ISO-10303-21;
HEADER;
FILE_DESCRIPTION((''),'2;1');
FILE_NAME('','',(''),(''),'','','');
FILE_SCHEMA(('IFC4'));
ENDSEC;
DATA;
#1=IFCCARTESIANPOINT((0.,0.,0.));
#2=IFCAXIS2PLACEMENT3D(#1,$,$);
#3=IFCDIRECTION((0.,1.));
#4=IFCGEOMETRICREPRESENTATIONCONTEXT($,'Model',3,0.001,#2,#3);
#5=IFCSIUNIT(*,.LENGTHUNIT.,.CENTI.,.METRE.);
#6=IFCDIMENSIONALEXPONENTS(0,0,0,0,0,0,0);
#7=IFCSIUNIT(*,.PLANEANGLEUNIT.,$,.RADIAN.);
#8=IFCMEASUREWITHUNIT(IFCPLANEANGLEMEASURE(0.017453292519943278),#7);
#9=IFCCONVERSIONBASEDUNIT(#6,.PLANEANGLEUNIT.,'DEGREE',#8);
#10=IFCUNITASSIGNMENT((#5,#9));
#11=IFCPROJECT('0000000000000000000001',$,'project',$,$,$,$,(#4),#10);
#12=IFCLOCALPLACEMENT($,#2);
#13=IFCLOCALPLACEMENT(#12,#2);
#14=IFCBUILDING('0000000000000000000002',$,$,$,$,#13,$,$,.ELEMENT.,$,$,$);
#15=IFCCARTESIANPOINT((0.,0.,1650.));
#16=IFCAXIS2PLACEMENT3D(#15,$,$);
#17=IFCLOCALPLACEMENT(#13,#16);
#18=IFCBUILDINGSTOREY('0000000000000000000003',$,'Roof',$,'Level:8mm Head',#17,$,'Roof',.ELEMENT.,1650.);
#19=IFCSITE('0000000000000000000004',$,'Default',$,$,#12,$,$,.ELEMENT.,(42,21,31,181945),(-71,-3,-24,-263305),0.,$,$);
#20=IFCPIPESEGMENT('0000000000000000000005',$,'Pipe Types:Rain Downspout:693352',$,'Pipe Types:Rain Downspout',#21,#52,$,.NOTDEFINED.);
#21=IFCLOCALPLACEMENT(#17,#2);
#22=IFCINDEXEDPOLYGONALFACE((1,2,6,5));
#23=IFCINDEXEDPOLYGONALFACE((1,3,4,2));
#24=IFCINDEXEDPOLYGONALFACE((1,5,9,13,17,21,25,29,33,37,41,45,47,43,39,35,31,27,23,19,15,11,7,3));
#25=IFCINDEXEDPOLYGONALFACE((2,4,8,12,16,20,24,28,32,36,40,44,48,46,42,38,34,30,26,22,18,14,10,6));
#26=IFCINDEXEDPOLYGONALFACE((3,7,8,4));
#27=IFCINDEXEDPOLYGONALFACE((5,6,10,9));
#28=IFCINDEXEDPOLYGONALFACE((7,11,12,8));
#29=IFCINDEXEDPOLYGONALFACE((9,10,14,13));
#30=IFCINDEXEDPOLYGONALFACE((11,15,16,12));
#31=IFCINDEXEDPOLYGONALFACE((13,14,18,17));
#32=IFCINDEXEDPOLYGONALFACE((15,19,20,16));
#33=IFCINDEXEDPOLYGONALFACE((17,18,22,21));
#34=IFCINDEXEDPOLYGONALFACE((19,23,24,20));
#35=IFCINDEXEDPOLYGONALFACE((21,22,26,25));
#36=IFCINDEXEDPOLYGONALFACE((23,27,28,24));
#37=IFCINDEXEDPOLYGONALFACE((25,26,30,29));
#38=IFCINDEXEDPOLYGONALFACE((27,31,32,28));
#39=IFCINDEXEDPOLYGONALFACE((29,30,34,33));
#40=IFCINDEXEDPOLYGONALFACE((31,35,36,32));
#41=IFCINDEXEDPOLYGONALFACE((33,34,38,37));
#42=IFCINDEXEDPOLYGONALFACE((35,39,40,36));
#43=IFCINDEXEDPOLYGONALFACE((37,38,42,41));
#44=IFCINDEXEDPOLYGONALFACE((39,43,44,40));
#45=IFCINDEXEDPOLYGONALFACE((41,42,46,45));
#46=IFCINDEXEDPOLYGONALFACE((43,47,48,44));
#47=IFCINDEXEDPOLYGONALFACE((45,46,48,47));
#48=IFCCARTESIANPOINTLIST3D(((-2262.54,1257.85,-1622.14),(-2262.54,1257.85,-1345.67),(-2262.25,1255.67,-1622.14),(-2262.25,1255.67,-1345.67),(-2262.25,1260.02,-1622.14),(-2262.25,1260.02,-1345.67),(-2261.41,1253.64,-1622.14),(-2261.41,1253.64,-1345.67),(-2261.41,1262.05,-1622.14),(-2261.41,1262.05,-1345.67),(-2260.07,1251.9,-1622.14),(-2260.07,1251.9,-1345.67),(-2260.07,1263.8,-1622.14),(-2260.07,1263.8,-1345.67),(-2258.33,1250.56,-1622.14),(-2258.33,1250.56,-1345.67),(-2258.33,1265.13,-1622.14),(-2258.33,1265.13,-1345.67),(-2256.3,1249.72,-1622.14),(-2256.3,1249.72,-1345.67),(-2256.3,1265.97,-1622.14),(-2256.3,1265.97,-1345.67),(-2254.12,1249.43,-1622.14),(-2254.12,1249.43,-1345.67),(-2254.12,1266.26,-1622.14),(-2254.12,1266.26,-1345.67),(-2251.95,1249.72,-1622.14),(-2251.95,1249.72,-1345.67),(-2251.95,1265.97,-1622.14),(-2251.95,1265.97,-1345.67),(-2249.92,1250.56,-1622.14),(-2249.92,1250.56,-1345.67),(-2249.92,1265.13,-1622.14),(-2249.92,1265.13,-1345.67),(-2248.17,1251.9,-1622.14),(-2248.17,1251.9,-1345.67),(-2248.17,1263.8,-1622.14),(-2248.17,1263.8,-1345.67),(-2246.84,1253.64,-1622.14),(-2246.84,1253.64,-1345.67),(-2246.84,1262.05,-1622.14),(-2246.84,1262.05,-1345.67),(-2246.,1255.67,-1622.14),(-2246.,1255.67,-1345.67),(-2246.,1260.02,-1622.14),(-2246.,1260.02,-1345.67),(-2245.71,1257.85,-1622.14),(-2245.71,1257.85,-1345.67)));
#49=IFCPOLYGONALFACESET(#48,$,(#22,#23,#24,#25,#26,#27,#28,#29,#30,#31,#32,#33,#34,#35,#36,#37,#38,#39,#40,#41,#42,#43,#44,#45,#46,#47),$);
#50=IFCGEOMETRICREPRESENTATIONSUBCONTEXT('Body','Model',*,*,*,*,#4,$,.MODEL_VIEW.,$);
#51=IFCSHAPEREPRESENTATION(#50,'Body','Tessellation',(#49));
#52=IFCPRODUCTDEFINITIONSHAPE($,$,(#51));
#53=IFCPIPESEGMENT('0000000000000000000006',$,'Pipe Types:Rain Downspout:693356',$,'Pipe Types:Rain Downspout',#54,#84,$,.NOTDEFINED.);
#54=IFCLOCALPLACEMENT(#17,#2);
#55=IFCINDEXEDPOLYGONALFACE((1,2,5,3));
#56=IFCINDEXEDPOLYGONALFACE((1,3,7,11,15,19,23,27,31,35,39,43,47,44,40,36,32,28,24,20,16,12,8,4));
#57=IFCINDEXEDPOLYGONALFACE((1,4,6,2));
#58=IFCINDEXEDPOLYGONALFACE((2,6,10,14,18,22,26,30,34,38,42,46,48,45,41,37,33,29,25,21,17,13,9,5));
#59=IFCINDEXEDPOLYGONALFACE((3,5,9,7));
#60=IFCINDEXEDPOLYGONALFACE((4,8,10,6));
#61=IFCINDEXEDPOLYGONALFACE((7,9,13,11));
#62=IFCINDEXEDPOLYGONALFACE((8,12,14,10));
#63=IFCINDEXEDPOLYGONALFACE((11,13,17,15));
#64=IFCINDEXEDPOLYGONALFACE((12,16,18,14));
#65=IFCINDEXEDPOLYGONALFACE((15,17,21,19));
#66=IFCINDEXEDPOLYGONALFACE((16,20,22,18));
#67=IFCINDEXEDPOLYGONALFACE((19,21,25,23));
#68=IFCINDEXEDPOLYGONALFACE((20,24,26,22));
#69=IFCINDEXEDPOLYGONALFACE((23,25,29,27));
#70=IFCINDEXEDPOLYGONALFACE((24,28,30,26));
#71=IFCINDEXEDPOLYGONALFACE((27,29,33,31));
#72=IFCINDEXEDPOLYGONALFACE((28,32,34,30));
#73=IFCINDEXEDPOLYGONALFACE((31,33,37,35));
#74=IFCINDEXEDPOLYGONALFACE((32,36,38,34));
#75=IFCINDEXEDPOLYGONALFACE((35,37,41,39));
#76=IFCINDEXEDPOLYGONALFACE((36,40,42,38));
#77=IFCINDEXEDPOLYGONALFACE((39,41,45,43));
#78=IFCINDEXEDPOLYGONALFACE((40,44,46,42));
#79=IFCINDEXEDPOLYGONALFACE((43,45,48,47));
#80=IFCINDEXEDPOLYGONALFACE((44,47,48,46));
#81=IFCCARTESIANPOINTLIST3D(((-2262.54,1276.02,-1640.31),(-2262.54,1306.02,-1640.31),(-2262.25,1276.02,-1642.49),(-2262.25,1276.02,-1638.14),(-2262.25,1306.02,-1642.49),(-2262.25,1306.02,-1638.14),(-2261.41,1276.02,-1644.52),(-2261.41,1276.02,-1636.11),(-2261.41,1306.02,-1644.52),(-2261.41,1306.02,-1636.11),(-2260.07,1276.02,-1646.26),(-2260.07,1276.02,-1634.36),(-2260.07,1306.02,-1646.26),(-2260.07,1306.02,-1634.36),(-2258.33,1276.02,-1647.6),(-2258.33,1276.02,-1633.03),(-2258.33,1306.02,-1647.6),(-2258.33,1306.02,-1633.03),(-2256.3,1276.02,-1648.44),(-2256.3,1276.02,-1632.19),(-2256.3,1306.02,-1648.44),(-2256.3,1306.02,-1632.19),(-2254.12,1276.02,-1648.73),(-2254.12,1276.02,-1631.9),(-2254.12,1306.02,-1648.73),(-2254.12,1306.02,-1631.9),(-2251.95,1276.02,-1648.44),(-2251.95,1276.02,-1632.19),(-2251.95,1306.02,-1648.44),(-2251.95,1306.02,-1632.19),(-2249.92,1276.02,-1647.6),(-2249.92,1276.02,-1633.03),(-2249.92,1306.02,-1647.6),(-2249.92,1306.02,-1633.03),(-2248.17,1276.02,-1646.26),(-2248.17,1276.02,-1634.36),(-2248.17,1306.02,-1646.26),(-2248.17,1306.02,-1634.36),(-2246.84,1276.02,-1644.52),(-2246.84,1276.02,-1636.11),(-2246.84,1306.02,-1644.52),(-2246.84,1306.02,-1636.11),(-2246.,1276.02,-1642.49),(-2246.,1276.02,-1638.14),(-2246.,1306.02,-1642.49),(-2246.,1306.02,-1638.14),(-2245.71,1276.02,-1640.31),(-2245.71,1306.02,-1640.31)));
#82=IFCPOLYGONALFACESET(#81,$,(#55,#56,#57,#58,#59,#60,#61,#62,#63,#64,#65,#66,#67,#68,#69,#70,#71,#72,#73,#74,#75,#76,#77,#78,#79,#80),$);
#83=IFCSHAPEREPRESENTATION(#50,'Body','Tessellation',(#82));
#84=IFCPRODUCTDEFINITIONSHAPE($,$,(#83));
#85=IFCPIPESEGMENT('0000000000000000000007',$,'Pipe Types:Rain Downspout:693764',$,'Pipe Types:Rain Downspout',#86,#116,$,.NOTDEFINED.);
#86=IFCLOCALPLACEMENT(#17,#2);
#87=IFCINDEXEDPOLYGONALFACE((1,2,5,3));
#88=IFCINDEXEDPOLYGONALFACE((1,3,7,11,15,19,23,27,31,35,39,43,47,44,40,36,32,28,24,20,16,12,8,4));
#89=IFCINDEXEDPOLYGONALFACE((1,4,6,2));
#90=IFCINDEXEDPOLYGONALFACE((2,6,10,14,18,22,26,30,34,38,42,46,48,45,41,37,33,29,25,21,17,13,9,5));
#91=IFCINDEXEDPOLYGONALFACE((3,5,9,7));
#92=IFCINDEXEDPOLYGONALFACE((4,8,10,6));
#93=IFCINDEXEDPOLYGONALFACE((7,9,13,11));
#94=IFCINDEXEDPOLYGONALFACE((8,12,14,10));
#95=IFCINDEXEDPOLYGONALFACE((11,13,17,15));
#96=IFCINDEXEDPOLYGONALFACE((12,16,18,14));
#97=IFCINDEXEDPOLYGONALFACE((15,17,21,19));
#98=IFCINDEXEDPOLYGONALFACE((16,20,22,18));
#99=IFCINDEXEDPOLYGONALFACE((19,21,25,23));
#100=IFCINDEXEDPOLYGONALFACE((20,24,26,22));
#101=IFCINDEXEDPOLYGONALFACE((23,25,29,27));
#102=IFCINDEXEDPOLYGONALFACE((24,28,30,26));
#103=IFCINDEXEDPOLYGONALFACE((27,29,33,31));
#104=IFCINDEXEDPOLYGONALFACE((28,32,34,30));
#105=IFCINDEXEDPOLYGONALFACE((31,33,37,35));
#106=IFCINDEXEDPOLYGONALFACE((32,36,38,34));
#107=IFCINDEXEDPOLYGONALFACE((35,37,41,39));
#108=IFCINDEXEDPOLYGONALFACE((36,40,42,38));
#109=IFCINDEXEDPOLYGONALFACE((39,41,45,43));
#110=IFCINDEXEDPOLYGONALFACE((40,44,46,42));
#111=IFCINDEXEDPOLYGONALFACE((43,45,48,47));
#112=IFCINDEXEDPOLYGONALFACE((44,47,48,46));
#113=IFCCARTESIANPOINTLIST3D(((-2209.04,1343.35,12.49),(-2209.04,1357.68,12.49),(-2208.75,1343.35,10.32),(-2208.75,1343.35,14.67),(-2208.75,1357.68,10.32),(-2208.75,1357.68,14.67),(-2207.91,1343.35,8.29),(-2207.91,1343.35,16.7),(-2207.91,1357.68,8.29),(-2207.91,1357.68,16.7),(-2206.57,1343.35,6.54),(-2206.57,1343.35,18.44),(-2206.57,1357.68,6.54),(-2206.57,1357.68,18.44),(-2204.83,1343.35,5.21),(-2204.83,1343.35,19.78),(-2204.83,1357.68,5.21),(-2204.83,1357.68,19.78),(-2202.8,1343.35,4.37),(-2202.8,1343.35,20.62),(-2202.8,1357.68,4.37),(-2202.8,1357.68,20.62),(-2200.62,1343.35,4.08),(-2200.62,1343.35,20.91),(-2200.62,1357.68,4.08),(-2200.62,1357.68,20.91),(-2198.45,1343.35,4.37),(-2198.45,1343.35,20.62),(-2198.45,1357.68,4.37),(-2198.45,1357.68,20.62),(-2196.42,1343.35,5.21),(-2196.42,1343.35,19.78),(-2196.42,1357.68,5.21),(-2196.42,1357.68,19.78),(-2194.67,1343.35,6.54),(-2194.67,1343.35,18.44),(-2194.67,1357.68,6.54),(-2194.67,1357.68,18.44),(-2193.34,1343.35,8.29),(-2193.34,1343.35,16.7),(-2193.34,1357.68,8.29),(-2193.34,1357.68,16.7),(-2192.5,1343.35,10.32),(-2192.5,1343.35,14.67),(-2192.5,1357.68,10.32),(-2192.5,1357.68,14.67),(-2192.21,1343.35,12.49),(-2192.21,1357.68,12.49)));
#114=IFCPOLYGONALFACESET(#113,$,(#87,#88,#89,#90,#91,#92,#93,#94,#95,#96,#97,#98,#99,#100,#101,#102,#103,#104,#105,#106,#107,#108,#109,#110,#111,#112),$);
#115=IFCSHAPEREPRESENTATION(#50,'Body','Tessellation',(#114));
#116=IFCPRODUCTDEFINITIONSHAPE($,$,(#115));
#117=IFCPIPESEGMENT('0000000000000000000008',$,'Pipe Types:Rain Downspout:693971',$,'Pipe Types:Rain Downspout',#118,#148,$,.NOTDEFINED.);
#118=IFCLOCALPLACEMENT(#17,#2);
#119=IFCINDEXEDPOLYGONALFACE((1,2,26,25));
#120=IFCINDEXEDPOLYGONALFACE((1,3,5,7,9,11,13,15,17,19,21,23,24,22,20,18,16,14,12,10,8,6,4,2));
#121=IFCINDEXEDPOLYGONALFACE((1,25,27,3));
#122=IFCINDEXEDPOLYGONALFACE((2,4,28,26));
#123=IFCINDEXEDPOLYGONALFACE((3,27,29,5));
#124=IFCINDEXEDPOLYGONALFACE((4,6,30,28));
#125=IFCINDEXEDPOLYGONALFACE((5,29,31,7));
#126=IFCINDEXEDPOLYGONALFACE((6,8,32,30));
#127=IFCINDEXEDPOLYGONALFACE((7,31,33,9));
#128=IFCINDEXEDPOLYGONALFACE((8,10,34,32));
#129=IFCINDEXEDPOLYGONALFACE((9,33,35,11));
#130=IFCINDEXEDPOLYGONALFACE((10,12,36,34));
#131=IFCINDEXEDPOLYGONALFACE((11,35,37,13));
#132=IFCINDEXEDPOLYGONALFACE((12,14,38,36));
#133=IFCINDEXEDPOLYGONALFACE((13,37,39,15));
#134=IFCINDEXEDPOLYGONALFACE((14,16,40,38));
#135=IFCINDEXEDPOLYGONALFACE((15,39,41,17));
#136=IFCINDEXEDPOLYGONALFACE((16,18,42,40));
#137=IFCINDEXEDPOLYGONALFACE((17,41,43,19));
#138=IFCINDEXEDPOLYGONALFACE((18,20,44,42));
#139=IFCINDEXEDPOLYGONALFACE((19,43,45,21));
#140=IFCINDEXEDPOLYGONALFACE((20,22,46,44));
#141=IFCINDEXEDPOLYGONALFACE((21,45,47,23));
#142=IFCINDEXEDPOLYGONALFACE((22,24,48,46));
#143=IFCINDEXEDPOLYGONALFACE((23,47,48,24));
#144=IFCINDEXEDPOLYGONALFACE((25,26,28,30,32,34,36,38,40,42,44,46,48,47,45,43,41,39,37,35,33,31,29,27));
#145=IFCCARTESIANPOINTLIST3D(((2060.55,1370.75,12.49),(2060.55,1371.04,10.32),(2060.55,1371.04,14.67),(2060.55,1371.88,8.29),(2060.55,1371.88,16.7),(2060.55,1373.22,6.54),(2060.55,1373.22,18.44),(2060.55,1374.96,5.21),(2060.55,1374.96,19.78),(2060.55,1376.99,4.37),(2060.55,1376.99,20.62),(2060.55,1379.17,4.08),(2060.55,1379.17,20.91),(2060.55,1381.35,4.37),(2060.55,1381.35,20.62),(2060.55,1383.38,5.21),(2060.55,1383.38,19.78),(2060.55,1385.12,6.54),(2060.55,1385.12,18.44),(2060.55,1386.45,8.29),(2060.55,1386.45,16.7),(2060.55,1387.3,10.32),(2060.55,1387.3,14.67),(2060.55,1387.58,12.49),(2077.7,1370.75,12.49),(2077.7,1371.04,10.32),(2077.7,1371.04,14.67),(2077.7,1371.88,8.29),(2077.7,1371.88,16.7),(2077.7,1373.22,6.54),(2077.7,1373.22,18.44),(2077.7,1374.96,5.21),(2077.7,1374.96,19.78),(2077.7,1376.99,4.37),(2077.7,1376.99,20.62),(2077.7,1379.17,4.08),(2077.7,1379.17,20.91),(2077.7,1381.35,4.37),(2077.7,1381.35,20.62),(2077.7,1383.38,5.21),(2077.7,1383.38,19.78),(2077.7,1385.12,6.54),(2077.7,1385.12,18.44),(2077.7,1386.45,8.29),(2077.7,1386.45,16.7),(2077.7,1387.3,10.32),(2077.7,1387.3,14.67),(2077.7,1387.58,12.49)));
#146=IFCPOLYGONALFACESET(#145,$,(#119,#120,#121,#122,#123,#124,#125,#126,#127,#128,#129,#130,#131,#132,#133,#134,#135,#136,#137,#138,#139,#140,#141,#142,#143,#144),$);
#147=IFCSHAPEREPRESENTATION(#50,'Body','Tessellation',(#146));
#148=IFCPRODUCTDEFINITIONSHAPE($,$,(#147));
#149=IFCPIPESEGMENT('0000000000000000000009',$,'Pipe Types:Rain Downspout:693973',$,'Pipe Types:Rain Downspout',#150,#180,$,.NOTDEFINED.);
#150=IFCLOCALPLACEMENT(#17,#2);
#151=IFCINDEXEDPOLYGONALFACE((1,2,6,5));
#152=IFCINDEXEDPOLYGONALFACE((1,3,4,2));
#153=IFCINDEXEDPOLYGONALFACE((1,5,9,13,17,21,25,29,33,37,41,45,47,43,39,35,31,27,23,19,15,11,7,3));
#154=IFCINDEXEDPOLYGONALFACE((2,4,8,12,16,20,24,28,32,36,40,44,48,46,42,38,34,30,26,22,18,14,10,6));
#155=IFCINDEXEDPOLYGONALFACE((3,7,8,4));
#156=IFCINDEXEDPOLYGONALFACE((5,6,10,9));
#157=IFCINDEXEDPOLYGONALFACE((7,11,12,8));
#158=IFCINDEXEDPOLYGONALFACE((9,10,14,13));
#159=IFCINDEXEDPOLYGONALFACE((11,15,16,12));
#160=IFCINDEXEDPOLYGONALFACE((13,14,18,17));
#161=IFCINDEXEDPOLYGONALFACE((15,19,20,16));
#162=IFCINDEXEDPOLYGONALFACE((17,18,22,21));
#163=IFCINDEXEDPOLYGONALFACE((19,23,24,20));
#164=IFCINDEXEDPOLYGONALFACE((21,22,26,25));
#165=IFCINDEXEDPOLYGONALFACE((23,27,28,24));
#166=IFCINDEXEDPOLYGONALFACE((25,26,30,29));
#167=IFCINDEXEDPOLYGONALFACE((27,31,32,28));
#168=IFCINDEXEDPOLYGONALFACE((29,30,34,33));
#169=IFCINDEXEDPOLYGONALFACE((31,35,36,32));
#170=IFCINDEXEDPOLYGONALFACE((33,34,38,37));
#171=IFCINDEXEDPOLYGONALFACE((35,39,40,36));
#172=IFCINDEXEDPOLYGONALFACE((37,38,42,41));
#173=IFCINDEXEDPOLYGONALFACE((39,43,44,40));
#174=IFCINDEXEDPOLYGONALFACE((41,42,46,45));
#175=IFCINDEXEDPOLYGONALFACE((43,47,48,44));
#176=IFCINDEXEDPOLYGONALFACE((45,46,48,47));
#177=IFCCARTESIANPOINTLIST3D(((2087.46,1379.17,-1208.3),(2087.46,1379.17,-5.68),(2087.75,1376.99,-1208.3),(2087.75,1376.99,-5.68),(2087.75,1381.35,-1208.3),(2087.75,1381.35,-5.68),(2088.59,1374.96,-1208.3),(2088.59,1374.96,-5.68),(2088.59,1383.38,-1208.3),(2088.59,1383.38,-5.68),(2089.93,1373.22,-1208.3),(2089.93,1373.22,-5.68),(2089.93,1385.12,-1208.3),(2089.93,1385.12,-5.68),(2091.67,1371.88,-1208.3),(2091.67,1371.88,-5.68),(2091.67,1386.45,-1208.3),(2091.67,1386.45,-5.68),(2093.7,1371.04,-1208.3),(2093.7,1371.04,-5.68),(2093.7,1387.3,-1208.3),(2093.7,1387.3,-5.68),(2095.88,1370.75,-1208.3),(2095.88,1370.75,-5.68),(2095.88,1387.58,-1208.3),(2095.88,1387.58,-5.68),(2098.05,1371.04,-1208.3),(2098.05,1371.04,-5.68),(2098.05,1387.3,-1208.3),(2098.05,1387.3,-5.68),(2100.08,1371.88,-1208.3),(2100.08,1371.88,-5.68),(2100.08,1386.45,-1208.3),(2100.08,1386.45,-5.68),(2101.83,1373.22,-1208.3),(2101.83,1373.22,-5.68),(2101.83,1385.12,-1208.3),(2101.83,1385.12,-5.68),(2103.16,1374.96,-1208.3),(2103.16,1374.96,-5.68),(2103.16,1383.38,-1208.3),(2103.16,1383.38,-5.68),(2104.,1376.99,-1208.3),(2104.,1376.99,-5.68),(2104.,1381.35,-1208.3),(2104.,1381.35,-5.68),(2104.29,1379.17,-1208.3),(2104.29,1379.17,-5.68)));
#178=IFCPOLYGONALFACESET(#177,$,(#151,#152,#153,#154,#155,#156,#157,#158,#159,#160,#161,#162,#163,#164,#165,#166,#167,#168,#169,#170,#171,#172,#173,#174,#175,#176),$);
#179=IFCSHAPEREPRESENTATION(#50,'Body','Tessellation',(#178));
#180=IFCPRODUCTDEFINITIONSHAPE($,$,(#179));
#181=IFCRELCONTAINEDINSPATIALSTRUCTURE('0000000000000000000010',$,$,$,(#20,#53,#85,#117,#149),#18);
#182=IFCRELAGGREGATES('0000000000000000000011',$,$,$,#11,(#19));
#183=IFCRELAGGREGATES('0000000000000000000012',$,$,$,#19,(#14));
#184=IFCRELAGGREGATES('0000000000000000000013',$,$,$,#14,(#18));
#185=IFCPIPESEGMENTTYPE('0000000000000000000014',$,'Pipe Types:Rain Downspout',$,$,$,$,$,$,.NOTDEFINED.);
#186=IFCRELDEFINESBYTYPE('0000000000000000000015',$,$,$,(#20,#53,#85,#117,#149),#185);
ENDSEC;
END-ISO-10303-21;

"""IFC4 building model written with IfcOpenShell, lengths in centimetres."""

from ifc_helpers import new_model, entity, si_unit, converted_unit, direction, frame, origin, place, context, subcontext, project, spatial, arc, indexed_curve, outline, extrude, type_object, element, save


model = new_model("IFC4")

# Units and contexts
model_context = context("Model", 3, precision=0.001, world=origin(), true_north=direction((0.0, 1.0)))
body_context = subcontext(model_context, "Body", "Model", "MODEL_VIEW")
ifc_project = project(units=[si_unit("LENGTHUNIT", "METRE", prefix="CENTI"), converted_unit("PLANEANGLEUNIT", "DEGREE", entity("IfcPlaneAngleMeasure", 0.017453292519943278), si_unit("PLANEANGLEUNIT", "RADIAN"), dimensions=[0, 0, 0, 0, 0, 0, 0])], contexts=[model_context])

# Site, building, storey
site_placement = place(None, origin())
site = spatial("IfcSite", under=ifc_project, at=site_placement, Name="Default", CompositionType="ELEMENT", RefLatitude=(42, 21, 31, 181945), RefLongitude=(-71, -3, -24, -263305), RefElevation=0.0)
building_placement = place(site_placement, origin())
building = spatial("IfcBuilding", under=site, at=building_placement, CompositionType="ELEMENT")
storey_placement = place(building_placement, frame((0.0, 0.0, 1650.0)))
storey = spatial("IfcBuildingStorey", under=building, at=storey_placement, Name="Roof", ObjectType="Level:8mm Head", LongName="Roof", CompositionType="ELEMENT", Elevation=1650.0)

# Pipe segments
pipe_segment_type = type_object("IfcPipeSegmentType", Name="Pipe Types:Rain Downspout", PredefinedType="NOTDEFINED")
pipe_segment_1_placement = place(storey_placement, origin())
element("IfcPipeSegment", 1, at=pipe_segment_1_placement, inside=storey, type_object=pipe_segment_type, Name="Pipe Types:Rain Downspout:693352", ObjectType="Pipe Types:Rain Downspout", PredefinedType="NOTDEFINED", context=body_context, shape_type="SweptSolid", body=[
    extrude(outline(indexed_curve([(8.41, 0.0), (5.95, 5.95), (0.0, 8.41), (-5.95, 5.95), (-8.41, 0.0), (-5.95, -5.95), (0.0, -8.41), (5.95, -5.95)], segments=[arc(1, 2, 3), arc(3, 4, 5), arc(5, 6, 7), arc(7, 8, 1)], self_intersect=False)), frame((-2254.12, 1257.85, -1622.14)), (0.0, 0.0, 1.0), 276.47),
])
pipe_segment_2_placement = place(storey_placement, origin())
element("IfcPipeSegment", 2, at=pipe_segment_2_placement, inside=storey, type_object=pipe_segment_type, Name="Pipe Types:Rain Downspout:693356", ObjectType="Pipe Types:Rain Downspout", PredefinedType="NOTDEFINED", context=body_context, shape_type="SweptSolid", body=[
    extrude(outline(indexed_curve([(8.41, 0.0), (5.95, 5.95), (0.0, 8.41), (-5.95, 5.95), (-8.41, 0.0), (-5.95, -5.95), (0.0, -8.41), (5.95, -5.95)], segments=[arc(1, 2, 3), arc(3, 4, 5), arc(5, 6, 7), arc(7, 8, 1)], self_intersect=False)), frame((-2254.12, 1276.02, -1640.31), z_axis=(0.0, 1.0, 0.0), x_axis=(1.0, 0.0, 0.0)), (0.0, 0.0, 1.0), 30.0),
])
pipe_segment_3_placement = place(storey_placement, origin())
element("IfcPipeSegment", 3, at=pipe_segment_3_placement, inside=storey, type_object=pipe_segment_type, Name="Pipe Types:Rain Downspout:693764", ObjectType="Pipe Types:Rain Downspout", PredefinedType="NOTDEFINED", context=body_context, shape_type="SweptSolid", body=[
    extrude(outline(indexed_curve([(8.41, 0.0), (5.95, 5.95), (0.0, 8.41), (-5.95, 5.95), (-8.41, 0.0), (-5.95, -5.95), (0.0, -8.41), (5.95, -5.95)], segments=[arc(1, 2, 3), arc(3, 4, 5), arc(5, 6, 7), arc(7, 8, 1)], self_intersect=False)), frame((-2200.62, 1343.35, 12.49), z_axis=(0.0, 1.0, 0.0), x_axis=(-1.0, 0.0, 0.0)), (0.0, 0.0, 1.0), 14.34),
])
pipe_segment_4_placement = place(storey_placement, origin())
element("IfcPipeSegment", 4, at=pipe_segment_4_placement, inside=storey, type_object=pipe_segment_type, Name="Pipe Types:Rain Downspout:693971", ObjectType="Pipe Types:Rain Downspout", PredefinedType="NOTDEFINED", context=body_context, shape_type="SweptSolid", body=[
    extrude(outline(indexed_curve([(8.41, 0.0), (5.95, 5.95), (0.0, 8.41), (-5.95, 5.95), (-8.41, 0.0), (-5.95, -5.95), (0.0, -8.41), (5.95, -5.95)], segments=[arc(1, 2, 3), arc(3, 4, 5), arc(5, 6, 7), arc(7, 8, 1)], self_intersect=False)), frame((2060.55, 1379.17, 12.49), z_axis=(1.0, 0.0, 0.0), x_axis=(0.0, 1.0, 0.0)), (0.0, 0.0, 1.0), 17.15),
])
pipe_segment_5_placement = place(storey_placement, origin())
element("IfcPipeSegment", 5, at=pipe_segment_5_placement, inside=storey, type_object=pipe_segment_type, Name="Pipe Types:Rain Downspout:693973", ObjectType="Pipe Types:Rain Downspout", PredefinedType="NOTDEFINED", context=body_context, shape_type="SweptSolid", body=[
    extrude(outline(indexed_curve([(8.41, 0.0), (5.95, 5.95), (0.0, 8.41), (-5.95, 5.95), (-8.41, 0.0), (-5.95, -5.95), (0.0, -8.41), (5.95, -5.95)], segments=[arc(1, 2, 3), arc(3, 4, 5), arc(5, 6, 7), arc(7, 8, 1)], self_intersect=False)), frame((2095.88, 1379.17, -1208.3)), (0.0, 0.0, 1.0), 1202.62),
])

save(model, "model.ifc")
